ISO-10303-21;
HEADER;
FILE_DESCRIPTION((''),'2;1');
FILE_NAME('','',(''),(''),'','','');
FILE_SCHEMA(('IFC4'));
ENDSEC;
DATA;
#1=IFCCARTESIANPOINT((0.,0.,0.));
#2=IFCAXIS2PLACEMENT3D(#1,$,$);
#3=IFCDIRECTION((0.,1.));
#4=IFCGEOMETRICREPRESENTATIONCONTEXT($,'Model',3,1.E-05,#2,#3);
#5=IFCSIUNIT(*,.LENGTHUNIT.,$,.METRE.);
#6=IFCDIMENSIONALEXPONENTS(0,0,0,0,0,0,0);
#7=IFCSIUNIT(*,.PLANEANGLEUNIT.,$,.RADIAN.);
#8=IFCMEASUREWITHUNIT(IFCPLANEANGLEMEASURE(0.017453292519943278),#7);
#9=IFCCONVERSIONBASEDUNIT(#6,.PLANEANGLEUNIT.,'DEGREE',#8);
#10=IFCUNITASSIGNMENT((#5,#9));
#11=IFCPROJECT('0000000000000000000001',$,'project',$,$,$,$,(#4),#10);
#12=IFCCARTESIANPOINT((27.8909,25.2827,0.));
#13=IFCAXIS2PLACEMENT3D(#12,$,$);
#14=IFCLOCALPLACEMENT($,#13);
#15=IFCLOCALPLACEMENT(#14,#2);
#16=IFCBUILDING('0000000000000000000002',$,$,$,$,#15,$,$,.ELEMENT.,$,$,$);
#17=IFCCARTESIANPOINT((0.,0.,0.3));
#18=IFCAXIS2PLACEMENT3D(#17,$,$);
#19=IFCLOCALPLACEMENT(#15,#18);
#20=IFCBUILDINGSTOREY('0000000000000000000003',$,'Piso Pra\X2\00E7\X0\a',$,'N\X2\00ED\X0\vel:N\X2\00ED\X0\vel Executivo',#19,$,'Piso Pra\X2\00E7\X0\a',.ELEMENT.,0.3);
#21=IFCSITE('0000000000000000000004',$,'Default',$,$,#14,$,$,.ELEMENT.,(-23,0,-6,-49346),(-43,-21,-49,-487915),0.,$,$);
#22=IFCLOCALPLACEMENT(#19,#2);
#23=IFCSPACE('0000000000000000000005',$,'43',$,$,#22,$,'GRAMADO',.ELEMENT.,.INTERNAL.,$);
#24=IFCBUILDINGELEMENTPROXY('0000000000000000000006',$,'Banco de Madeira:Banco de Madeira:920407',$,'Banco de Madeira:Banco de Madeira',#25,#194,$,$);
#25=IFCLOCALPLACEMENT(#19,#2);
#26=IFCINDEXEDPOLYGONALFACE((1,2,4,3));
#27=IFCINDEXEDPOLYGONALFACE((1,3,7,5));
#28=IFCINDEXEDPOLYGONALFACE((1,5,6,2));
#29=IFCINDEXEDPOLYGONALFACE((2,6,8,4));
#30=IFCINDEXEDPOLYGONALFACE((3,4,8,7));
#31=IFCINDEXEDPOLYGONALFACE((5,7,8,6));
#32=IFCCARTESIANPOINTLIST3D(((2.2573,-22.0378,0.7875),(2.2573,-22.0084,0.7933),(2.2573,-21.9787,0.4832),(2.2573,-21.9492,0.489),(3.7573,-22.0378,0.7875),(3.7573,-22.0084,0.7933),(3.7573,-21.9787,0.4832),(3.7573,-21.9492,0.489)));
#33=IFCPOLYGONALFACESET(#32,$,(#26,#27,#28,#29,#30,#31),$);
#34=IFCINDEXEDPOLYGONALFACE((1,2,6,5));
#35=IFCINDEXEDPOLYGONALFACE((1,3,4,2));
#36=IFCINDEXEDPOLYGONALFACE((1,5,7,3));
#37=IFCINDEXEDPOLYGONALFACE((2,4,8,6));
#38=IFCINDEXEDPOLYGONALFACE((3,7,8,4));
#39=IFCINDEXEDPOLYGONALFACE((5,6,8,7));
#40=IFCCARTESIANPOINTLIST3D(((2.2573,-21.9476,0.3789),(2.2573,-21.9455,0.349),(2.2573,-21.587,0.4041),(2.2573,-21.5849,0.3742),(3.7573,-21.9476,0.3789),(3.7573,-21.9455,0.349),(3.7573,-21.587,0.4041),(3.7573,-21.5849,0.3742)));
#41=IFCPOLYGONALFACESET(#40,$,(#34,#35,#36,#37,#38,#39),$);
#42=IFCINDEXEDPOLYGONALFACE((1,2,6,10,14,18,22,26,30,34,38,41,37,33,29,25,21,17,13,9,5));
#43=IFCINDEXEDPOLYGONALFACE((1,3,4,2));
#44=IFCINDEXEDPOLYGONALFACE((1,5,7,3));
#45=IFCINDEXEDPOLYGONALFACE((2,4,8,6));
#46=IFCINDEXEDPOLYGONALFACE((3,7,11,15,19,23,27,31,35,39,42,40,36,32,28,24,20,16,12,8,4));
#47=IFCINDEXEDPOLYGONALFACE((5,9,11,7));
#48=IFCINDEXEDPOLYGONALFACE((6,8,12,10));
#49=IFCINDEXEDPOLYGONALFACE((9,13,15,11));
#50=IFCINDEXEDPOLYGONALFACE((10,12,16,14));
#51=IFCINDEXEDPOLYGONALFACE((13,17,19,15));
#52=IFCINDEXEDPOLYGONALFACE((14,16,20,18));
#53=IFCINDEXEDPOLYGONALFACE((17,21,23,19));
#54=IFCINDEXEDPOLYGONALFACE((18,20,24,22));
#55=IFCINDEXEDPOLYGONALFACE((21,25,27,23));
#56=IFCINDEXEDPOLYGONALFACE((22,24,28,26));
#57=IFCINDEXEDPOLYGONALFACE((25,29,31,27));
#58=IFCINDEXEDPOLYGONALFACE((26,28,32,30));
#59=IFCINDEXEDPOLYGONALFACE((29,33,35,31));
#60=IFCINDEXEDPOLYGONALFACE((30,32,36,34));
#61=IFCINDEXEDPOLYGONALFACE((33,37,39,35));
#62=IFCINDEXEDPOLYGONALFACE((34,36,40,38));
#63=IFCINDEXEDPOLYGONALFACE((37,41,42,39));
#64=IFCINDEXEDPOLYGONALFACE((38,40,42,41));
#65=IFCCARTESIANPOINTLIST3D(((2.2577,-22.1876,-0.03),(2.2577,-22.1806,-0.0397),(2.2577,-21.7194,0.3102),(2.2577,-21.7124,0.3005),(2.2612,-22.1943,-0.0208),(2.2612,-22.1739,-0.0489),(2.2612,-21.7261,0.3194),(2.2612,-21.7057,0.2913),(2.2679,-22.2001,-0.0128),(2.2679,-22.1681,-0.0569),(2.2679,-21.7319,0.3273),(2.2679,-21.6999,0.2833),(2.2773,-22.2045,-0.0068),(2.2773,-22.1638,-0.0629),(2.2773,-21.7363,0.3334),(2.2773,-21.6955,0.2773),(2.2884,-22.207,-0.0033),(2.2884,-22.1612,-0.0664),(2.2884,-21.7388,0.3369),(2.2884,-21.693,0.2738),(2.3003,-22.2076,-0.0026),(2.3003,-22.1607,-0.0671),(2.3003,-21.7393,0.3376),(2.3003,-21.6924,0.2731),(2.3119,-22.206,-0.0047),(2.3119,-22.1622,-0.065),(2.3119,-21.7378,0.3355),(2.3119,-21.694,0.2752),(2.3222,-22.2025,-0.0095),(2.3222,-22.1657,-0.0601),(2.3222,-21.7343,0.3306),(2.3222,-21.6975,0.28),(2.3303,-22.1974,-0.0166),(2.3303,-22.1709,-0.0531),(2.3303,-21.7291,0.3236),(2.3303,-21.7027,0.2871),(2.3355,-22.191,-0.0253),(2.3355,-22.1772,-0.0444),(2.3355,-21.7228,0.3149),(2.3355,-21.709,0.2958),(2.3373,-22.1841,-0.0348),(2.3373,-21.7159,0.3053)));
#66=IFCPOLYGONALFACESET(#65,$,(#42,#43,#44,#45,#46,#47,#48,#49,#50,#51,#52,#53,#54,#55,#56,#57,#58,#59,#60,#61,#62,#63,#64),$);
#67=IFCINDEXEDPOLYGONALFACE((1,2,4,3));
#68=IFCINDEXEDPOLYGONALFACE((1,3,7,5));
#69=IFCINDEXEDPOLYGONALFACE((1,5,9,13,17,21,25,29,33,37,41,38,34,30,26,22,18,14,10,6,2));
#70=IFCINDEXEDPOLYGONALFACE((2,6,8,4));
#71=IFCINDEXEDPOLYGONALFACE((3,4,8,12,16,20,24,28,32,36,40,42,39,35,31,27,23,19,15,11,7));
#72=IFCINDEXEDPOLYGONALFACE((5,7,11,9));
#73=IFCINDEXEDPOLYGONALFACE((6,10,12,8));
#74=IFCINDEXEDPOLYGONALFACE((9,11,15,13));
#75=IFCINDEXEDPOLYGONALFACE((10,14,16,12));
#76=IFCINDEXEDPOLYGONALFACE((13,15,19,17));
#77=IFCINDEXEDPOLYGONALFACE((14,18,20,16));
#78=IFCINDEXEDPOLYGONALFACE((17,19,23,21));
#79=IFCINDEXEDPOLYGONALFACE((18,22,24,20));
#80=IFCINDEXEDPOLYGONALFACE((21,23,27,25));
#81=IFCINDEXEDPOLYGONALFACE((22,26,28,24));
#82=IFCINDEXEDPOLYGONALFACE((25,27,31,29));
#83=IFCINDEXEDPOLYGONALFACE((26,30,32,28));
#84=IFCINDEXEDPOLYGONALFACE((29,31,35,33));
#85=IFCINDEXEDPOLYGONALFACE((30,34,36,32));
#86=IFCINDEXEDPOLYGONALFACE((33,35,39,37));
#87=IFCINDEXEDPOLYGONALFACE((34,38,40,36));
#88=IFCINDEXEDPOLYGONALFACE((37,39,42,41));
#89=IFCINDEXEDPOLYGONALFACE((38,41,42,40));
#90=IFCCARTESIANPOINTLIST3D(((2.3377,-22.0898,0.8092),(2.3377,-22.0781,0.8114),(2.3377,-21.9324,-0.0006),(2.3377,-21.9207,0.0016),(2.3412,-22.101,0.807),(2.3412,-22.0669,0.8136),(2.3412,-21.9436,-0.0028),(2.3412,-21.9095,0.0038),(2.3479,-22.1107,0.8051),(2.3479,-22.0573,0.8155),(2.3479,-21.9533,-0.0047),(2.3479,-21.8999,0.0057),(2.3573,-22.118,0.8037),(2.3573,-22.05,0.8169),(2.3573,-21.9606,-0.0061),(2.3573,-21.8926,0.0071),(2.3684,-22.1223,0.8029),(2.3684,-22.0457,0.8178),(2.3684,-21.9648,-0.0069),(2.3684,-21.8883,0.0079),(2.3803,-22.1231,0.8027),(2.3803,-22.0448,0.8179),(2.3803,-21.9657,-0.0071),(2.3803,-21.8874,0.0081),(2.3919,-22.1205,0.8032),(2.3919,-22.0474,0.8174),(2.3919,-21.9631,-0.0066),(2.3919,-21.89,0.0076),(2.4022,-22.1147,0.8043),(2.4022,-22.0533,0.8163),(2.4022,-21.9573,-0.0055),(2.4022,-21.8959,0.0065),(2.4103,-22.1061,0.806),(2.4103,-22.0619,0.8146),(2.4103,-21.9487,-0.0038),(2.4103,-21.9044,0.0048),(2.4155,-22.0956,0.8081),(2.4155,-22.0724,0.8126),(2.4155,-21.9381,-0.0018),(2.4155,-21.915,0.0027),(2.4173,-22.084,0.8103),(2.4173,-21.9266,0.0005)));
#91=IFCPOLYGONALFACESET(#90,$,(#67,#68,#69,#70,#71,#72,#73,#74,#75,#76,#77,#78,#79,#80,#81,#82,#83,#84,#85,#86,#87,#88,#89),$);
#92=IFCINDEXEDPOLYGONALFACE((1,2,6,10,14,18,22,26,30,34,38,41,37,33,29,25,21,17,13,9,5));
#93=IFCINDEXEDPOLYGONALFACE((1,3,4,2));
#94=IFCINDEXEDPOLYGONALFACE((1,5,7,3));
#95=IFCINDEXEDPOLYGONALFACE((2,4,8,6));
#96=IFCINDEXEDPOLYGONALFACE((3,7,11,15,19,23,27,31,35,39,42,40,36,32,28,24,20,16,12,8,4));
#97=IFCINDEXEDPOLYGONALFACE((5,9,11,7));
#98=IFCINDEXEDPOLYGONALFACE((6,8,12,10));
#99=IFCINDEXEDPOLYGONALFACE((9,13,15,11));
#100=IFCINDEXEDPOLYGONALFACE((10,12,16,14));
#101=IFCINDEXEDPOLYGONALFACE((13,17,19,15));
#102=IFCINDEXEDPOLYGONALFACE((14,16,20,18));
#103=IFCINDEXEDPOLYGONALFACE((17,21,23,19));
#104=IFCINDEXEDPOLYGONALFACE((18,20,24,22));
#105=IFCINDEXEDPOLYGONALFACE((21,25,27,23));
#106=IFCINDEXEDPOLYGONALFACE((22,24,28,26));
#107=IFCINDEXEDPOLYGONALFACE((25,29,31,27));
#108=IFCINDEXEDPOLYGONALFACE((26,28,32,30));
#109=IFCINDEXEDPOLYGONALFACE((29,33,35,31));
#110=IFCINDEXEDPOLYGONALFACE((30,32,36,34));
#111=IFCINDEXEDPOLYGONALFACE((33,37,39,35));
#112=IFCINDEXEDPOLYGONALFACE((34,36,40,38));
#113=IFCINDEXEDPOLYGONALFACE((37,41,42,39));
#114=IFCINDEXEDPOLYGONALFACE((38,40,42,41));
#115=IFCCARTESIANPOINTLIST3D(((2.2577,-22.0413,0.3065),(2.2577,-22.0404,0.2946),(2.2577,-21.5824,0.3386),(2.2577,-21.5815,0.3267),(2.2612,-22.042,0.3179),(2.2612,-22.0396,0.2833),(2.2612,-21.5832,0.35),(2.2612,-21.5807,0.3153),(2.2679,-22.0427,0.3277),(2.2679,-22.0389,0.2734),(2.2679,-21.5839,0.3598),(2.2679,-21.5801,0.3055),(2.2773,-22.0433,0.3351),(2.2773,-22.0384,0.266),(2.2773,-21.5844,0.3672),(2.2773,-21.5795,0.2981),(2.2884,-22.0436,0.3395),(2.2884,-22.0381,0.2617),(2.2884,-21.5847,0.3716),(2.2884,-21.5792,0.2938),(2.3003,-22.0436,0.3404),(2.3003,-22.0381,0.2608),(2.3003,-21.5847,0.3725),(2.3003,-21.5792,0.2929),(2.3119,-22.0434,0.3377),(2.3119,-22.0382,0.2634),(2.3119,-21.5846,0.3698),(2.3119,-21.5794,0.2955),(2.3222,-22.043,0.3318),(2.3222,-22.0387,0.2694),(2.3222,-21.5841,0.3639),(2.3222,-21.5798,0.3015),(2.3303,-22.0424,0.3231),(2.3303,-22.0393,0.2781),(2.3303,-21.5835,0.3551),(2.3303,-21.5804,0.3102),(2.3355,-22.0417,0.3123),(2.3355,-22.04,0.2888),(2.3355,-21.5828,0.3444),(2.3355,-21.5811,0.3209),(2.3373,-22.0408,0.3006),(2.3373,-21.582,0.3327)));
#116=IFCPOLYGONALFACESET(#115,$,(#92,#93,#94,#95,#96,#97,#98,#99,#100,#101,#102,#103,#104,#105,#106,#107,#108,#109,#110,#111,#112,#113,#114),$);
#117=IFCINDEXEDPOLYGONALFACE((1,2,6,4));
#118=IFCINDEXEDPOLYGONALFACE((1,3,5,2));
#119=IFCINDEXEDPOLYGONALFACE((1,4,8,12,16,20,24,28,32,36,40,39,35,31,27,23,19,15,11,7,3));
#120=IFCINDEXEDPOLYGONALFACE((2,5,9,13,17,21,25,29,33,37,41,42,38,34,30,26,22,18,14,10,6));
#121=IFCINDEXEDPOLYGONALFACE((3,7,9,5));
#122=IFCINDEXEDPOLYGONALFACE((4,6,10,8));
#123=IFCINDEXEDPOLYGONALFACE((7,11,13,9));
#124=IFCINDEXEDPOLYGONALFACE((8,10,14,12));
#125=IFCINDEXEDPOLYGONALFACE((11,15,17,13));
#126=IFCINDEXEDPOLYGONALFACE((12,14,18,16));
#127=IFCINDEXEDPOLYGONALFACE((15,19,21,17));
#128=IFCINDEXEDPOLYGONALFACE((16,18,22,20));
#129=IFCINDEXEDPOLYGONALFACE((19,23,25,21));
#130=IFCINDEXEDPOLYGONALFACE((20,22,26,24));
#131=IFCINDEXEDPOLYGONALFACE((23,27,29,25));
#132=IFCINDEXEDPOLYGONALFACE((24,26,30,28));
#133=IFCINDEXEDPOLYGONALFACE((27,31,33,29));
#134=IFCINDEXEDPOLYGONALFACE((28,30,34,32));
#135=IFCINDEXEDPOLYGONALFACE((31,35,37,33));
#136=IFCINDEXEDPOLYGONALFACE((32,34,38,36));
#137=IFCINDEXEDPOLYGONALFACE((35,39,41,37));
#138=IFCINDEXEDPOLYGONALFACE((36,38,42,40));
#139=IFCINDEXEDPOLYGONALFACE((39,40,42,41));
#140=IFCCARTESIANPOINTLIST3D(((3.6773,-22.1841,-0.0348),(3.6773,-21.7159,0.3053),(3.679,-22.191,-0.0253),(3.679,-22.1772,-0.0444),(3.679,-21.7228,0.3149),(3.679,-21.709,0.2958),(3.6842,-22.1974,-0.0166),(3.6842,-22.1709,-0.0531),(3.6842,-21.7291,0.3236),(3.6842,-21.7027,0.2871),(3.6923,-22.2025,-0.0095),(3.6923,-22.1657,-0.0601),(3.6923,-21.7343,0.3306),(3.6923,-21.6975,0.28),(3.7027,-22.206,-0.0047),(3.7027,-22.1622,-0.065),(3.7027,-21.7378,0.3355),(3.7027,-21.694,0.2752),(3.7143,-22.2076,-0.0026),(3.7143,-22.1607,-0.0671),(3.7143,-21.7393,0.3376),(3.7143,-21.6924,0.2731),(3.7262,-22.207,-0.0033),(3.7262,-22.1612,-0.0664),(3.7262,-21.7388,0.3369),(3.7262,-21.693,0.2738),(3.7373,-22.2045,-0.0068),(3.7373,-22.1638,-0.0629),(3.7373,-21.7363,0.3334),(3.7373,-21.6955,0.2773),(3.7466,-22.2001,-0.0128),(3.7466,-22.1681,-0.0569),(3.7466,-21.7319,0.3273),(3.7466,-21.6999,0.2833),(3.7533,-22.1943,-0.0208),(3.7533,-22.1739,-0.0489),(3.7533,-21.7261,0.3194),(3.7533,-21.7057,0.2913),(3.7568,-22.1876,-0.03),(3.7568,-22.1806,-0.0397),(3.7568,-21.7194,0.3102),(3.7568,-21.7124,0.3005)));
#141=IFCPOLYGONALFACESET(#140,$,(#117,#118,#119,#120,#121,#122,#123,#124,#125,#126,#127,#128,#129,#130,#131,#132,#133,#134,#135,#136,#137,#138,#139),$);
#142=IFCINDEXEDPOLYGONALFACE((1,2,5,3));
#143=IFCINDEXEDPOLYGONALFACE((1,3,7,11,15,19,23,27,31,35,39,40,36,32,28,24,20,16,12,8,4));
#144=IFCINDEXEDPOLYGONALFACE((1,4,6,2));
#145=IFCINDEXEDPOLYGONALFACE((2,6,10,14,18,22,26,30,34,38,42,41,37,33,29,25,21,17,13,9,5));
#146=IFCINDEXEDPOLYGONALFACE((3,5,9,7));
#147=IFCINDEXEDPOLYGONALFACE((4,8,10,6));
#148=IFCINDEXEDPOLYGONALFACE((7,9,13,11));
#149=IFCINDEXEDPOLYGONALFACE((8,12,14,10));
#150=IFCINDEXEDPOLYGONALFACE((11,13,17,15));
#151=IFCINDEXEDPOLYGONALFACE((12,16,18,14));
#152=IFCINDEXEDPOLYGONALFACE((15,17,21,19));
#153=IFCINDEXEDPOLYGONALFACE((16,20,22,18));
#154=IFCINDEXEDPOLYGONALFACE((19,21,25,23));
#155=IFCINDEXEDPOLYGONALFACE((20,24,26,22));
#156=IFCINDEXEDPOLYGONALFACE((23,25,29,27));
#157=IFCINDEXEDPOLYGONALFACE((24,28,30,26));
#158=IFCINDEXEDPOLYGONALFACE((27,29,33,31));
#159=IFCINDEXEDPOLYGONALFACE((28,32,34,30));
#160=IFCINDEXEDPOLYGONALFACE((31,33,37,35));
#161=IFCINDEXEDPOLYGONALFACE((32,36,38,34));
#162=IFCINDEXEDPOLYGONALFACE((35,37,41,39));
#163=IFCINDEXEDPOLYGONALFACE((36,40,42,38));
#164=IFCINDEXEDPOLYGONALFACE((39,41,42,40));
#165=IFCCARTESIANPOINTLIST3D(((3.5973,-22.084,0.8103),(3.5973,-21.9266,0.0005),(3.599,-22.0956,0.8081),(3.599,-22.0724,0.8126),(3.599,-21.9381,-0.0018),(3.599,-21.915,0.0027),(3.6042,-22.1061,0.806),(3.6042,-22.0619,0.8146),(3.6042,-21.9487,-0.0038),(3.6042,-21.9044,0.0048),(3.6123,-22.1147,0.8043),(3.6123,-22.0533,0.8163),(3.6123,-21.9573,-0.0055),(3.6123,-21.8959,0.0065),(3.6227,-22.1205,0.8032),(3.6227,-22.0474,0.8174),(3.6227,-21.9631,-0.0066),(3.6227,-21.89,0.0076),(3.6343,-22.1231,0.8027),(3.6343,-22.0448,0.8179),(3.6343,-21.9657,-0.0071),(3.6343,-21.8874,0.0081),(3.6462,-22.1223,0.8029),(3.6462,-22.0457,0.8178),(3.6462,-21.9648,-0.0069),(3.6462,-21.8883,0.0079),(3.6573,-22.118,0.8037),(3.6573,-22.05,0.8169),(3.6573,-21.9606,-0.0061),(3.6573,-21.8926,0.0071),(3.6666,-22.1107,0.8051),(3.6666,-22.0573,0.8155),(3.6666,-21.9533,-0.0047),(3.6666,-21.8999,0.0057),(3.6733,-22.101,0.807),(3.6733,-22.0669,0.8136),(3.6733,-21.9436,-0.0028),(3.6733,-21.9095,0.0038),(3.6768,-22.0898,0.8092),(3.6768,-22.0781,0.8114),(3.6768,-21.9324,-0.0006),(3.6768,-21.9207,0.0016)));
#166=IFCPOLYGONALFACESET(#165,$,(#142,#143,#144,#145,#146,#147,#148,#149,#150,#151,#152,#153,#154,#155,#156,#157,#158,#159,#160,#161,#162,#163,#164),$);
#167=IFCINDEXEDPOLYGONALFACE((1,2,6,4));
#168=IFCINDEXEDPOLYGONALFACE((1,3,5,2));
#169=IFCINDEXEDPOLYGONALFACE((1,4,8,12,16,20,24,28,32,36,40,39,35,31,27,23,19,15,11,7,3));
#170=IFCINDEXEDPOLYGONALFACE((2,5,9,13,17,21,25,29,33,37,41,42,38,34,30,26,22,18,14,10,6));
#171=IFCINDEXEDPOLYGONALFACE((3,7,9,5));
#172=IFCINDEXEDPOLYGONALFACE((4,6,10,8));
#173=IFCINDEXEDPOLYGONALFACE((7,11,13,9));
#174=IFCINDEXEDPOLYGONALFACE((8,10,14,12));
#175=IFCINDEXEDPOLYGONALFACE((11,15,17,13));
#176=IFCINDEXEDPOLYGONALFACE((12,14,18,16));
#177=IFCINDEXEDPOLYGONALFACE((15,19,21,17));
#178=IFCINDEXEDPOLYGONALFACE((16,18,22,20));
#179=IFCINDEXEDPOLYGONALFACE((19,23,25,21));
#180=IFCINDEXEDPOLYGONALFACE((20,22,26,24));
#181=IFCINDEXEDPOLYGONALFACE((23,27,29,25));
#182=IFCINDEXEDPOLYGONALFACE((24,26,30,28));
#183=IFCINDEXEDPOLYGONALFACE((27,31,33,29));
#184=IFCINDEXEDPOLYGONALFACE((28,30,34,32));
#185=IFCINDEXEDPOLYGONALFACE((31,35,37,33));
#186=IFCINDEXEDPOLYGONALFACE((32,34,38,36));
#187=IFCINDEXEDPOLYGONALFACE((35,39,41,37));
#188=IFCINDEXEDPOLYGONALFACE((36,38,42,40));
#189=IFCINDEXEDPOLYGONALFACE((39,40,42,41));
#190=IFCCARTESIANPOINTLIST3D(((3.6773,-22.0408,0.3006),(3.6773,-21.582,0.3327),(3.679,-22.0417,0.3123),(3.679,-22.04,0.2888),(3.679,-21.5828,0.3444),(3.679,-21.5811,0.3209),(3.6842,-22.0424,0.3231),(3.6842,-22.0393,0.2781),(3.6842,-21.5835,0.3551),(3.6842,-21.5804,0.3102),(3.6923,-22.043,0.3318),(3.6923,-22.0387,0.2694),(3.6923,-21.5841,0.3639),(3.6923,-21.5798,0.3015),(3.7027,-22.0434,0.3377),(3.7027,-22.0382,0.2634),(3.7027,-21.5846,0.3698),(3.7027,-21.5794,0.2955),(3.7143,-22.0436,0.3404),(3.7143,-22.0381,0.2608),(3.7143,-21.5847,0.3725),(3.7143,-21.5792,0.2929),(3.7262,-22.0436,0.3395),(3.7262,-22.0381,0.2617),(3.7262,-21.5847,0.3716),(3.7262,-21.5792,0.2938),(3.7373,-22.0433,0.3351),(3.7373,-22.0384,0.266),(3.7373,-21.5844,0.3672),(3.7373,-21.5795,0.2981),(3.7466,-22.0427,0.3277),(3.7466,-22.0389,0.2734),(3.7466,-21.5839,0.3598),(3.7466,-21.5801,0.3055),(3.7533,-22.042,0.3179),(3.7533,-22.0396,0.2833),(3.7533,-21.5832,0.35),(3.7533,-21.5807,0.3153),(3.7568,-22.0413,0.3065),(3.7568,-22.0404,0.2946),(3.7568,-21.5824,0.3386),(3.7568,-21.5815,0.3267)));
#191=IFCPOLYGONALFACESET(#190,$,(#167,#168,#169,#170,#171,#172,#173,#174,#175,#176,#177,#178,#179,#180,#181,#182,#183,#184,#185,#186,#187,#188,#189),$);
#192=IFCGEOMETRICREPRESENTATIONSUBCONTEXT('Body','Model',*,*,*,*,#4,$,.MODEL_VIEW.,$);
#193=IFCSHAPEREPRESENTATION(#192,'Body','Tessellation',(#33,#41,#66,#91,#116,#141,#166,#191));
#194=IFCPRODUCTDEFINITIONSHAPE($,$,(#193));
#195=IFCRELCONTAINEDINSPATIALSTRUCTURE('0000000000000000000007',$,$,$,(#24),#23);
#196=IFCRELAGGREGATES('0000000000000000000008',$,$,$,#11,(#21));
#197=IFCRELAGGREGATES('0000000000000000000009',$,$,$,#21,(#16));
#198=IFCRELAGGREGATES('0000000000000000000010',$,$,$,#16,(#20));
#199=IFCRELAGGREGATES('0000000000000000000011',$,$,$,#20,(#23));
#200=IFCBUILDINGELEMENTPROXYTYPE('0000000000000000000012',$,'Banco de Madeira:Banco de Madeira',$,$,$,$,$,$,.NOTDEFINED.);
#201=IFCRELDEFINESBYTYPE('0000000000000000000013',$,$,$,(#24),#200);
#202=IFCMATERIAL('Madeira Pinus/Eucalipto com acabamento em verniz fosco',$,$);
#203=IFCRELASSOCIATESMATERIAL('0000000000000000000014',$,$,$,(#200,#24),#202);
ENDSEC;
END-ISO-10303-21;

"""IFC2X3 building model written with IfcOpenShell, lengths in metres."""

from ifc_helpers import new_model, entity, si_unit, converted_unit, direction, frame, frame_2d, origin, place, context, subcontext, project, spatial, rectangle, circle, extrude, source, transform, mapped, material, type_object, type_shapes, element, save


model = new_model("IFC2X3")

# Units and contexts
model_context = context("Model", 3, precision=1e-05, world=origin(), true_north=direction((0.0, 1.0)))
body_context = subcontext(model_context, "Body", "Model", "MODEL_VIEW")
ifc_project = project(units=[si_unit("LENGTHUNIT", "METRE"), converted_unit("PLANEANGLEUNIT", "DEGREE", entity("IfcPlaneAngleMeasure", 0.017453292519943278), si_unit("PLANEANGLEUNIT", "RADIAN"), dimensions=[0, 0, 0, 0, 0, 0, 0])], contexts=[model_context])

# Site, building, storey
site_placement = place(None, frame((27.8909, 25.2827, 0.0)))
site = spatial("IfcSite", under=ifc_project, at=site_placement, Name="Default", CompositionType="ELEMENT", RefLatitude=(-23, 0, -6, -49346), RefLongitude=(-43, -21, -49, -487915), RefElevation=0.0)
building_placement = place(site_placement, origin())
building = spatial("IfcBuilding", under=site, at=building_placement, CompositionType="ELEMENT")
storey_placement = place(building_placement, frame((0.0, 0.0, 0.3)))
storey = spatial("IfcBuildingStorey", under=building, at=storey_placement, Name="Piso Praça", ObjectType="Nível:Nível Executivo", LongName="Piso Praça", CompositionType="ELEMENT", Elevation=0.3)

# Shared definitions
space_1_placement = place(storey_placement, origin())
space_1 = spatial("IfcSpace", under=storey, at=space_1_placement, Name="43", LongName="GRAMADO", CompositionType="ELEMENT", InteriorOrExteriorSpace="INTERNAL")

# Building element proxy
ifc_material_1 = material(Name="Madeira Pinus/Eucalipto com acabamento em verniz fosco")
building_element_proxy_type_1 = type_object("IfcBuildingElementProxyType", Name="Banco de Madeira:Banco de Madeira", PredefinedType="NOTDEFINED", material=ifc_material_1)
shared_shape_1 = source(origin(), body_context, "Body", "SweptSolid", [
    extrude(rectangle(XDim=0.31, YDim=0.03, at=frame_2d((0.0, 0.0), x_axis=(1.0, 0.0))), frame((-0.75, 0.1439, 0.6383), z_axis=(1.0, 0.0, 0.0), x_axis=(0.0, 0.190809, 0.981627)), (0.0, 0.0, 1.0), 1.5),
    extrude(rectangle(XDim=0.03, YDim=0.3616, at=frame_2d((0.0, 0.0), x_axis=(0.0, 1.0))), frame((-0.75, -0.0833, 0.3765), z_axis=(1.0, 0.0, 0.0), x_axis=(0.0, 0.997564, -0.069756)), (0.0, 0.0, 1.0), 1.5),
    extrude(circle(Radius=0.04, at=frame_2d((0.0, 0.0), x_axis=(1.0, 0.0))), frame((0.71, 0.3345, -0.0348), z_axis=(0.0, -0.809017, 0.587785), x_axis=(-1.0, 0.0, 0.0)), (0.0, 0.0, 1.0), 0.5788),
    extrude(circle(Radius=0.04, at=frame_2d((0.0, 0.0), x_axis=(1.0, 0.0))), frame((0.63, 0.077, 0.0005), z_axis=(0.0, 0.190809, 0.981627), x_axis=(-1.0, 0.0, 0.0)), (0.0, 0.0, 1.0), 0.825),
    extrude(circle(Radius=0.04, at=frame_2d((0.0, 0.0), x_axis=(1.0, 0.0))), frame((0.71, -0.2676, 0.3327), z_axis=(0.0, 0.997564, -0.069756), x_axis=(-1.0, 0.0, 0.0)), (0.0, 0.0, 1.0), 0.46),
    extrude(circle(Radius=0.04, at=frame_2d((0.0, 0.0), x_axis=(1.0, 0.0))), frame((-0.71, 0.3345, -0.0348), z_axis=(0.0, -0.809017, 0.587785), x_axis=(1.0, 0.0, 0.0)), (0.0, 0.0, 1.0), 0.5788),
    extrude(circle(Radius=0.04, at=frame_2d((0.0, 0.0), x_axis=(1.0, 0.0))), frame((-0.63, 0.077, 0.0005), z_axis=(0.0, 0.190809, 0.981627), x_axis=(1.0, 0.0, 0.0)), (0.0, 0.0, 1.0), 0.825),
    extrude(circle(Radius=0.04, at=frame_2d((0.0, 0.0), x_axis=(1.0, 0.0))), frame((-0.71, -0.2676, 0.3327), z_axis=(0.0, 0.997564, -0.069756), x_axis=(1.0, 0.0, 0.0)), (0.0, 0.0, 1.0), 0.46),
])
type_shapes(building_element_proxy_type_1, [shared_shape_1])
for number, where, z_axis, x_axis, name in (
    (1, (3.0073, -21.8496, 0.0), (0.0, 0.0, 1.0), (-1.0, 0.0, 0.0), "Banco de Madeira:Banco de Madeira:920407"),
):
    element("IfcBuildingElementProxy", number, at=place(space_1_placement, frame(where, z_axis=z_axis, x_axis=x_axis)), inside=space_1, type_object=building_element_proxy_type_1, material=ifc_material_1, Name=name, ObjectType="Banco de Madeira:Banco de Madeira", context=body_context, shape_type="MappedRepresentation", body=[
        mapped(shared_shape_1, transform((0.0, 0.0, 0.0), scale=1.0)),
    ])

save(model, "model.ifc")
